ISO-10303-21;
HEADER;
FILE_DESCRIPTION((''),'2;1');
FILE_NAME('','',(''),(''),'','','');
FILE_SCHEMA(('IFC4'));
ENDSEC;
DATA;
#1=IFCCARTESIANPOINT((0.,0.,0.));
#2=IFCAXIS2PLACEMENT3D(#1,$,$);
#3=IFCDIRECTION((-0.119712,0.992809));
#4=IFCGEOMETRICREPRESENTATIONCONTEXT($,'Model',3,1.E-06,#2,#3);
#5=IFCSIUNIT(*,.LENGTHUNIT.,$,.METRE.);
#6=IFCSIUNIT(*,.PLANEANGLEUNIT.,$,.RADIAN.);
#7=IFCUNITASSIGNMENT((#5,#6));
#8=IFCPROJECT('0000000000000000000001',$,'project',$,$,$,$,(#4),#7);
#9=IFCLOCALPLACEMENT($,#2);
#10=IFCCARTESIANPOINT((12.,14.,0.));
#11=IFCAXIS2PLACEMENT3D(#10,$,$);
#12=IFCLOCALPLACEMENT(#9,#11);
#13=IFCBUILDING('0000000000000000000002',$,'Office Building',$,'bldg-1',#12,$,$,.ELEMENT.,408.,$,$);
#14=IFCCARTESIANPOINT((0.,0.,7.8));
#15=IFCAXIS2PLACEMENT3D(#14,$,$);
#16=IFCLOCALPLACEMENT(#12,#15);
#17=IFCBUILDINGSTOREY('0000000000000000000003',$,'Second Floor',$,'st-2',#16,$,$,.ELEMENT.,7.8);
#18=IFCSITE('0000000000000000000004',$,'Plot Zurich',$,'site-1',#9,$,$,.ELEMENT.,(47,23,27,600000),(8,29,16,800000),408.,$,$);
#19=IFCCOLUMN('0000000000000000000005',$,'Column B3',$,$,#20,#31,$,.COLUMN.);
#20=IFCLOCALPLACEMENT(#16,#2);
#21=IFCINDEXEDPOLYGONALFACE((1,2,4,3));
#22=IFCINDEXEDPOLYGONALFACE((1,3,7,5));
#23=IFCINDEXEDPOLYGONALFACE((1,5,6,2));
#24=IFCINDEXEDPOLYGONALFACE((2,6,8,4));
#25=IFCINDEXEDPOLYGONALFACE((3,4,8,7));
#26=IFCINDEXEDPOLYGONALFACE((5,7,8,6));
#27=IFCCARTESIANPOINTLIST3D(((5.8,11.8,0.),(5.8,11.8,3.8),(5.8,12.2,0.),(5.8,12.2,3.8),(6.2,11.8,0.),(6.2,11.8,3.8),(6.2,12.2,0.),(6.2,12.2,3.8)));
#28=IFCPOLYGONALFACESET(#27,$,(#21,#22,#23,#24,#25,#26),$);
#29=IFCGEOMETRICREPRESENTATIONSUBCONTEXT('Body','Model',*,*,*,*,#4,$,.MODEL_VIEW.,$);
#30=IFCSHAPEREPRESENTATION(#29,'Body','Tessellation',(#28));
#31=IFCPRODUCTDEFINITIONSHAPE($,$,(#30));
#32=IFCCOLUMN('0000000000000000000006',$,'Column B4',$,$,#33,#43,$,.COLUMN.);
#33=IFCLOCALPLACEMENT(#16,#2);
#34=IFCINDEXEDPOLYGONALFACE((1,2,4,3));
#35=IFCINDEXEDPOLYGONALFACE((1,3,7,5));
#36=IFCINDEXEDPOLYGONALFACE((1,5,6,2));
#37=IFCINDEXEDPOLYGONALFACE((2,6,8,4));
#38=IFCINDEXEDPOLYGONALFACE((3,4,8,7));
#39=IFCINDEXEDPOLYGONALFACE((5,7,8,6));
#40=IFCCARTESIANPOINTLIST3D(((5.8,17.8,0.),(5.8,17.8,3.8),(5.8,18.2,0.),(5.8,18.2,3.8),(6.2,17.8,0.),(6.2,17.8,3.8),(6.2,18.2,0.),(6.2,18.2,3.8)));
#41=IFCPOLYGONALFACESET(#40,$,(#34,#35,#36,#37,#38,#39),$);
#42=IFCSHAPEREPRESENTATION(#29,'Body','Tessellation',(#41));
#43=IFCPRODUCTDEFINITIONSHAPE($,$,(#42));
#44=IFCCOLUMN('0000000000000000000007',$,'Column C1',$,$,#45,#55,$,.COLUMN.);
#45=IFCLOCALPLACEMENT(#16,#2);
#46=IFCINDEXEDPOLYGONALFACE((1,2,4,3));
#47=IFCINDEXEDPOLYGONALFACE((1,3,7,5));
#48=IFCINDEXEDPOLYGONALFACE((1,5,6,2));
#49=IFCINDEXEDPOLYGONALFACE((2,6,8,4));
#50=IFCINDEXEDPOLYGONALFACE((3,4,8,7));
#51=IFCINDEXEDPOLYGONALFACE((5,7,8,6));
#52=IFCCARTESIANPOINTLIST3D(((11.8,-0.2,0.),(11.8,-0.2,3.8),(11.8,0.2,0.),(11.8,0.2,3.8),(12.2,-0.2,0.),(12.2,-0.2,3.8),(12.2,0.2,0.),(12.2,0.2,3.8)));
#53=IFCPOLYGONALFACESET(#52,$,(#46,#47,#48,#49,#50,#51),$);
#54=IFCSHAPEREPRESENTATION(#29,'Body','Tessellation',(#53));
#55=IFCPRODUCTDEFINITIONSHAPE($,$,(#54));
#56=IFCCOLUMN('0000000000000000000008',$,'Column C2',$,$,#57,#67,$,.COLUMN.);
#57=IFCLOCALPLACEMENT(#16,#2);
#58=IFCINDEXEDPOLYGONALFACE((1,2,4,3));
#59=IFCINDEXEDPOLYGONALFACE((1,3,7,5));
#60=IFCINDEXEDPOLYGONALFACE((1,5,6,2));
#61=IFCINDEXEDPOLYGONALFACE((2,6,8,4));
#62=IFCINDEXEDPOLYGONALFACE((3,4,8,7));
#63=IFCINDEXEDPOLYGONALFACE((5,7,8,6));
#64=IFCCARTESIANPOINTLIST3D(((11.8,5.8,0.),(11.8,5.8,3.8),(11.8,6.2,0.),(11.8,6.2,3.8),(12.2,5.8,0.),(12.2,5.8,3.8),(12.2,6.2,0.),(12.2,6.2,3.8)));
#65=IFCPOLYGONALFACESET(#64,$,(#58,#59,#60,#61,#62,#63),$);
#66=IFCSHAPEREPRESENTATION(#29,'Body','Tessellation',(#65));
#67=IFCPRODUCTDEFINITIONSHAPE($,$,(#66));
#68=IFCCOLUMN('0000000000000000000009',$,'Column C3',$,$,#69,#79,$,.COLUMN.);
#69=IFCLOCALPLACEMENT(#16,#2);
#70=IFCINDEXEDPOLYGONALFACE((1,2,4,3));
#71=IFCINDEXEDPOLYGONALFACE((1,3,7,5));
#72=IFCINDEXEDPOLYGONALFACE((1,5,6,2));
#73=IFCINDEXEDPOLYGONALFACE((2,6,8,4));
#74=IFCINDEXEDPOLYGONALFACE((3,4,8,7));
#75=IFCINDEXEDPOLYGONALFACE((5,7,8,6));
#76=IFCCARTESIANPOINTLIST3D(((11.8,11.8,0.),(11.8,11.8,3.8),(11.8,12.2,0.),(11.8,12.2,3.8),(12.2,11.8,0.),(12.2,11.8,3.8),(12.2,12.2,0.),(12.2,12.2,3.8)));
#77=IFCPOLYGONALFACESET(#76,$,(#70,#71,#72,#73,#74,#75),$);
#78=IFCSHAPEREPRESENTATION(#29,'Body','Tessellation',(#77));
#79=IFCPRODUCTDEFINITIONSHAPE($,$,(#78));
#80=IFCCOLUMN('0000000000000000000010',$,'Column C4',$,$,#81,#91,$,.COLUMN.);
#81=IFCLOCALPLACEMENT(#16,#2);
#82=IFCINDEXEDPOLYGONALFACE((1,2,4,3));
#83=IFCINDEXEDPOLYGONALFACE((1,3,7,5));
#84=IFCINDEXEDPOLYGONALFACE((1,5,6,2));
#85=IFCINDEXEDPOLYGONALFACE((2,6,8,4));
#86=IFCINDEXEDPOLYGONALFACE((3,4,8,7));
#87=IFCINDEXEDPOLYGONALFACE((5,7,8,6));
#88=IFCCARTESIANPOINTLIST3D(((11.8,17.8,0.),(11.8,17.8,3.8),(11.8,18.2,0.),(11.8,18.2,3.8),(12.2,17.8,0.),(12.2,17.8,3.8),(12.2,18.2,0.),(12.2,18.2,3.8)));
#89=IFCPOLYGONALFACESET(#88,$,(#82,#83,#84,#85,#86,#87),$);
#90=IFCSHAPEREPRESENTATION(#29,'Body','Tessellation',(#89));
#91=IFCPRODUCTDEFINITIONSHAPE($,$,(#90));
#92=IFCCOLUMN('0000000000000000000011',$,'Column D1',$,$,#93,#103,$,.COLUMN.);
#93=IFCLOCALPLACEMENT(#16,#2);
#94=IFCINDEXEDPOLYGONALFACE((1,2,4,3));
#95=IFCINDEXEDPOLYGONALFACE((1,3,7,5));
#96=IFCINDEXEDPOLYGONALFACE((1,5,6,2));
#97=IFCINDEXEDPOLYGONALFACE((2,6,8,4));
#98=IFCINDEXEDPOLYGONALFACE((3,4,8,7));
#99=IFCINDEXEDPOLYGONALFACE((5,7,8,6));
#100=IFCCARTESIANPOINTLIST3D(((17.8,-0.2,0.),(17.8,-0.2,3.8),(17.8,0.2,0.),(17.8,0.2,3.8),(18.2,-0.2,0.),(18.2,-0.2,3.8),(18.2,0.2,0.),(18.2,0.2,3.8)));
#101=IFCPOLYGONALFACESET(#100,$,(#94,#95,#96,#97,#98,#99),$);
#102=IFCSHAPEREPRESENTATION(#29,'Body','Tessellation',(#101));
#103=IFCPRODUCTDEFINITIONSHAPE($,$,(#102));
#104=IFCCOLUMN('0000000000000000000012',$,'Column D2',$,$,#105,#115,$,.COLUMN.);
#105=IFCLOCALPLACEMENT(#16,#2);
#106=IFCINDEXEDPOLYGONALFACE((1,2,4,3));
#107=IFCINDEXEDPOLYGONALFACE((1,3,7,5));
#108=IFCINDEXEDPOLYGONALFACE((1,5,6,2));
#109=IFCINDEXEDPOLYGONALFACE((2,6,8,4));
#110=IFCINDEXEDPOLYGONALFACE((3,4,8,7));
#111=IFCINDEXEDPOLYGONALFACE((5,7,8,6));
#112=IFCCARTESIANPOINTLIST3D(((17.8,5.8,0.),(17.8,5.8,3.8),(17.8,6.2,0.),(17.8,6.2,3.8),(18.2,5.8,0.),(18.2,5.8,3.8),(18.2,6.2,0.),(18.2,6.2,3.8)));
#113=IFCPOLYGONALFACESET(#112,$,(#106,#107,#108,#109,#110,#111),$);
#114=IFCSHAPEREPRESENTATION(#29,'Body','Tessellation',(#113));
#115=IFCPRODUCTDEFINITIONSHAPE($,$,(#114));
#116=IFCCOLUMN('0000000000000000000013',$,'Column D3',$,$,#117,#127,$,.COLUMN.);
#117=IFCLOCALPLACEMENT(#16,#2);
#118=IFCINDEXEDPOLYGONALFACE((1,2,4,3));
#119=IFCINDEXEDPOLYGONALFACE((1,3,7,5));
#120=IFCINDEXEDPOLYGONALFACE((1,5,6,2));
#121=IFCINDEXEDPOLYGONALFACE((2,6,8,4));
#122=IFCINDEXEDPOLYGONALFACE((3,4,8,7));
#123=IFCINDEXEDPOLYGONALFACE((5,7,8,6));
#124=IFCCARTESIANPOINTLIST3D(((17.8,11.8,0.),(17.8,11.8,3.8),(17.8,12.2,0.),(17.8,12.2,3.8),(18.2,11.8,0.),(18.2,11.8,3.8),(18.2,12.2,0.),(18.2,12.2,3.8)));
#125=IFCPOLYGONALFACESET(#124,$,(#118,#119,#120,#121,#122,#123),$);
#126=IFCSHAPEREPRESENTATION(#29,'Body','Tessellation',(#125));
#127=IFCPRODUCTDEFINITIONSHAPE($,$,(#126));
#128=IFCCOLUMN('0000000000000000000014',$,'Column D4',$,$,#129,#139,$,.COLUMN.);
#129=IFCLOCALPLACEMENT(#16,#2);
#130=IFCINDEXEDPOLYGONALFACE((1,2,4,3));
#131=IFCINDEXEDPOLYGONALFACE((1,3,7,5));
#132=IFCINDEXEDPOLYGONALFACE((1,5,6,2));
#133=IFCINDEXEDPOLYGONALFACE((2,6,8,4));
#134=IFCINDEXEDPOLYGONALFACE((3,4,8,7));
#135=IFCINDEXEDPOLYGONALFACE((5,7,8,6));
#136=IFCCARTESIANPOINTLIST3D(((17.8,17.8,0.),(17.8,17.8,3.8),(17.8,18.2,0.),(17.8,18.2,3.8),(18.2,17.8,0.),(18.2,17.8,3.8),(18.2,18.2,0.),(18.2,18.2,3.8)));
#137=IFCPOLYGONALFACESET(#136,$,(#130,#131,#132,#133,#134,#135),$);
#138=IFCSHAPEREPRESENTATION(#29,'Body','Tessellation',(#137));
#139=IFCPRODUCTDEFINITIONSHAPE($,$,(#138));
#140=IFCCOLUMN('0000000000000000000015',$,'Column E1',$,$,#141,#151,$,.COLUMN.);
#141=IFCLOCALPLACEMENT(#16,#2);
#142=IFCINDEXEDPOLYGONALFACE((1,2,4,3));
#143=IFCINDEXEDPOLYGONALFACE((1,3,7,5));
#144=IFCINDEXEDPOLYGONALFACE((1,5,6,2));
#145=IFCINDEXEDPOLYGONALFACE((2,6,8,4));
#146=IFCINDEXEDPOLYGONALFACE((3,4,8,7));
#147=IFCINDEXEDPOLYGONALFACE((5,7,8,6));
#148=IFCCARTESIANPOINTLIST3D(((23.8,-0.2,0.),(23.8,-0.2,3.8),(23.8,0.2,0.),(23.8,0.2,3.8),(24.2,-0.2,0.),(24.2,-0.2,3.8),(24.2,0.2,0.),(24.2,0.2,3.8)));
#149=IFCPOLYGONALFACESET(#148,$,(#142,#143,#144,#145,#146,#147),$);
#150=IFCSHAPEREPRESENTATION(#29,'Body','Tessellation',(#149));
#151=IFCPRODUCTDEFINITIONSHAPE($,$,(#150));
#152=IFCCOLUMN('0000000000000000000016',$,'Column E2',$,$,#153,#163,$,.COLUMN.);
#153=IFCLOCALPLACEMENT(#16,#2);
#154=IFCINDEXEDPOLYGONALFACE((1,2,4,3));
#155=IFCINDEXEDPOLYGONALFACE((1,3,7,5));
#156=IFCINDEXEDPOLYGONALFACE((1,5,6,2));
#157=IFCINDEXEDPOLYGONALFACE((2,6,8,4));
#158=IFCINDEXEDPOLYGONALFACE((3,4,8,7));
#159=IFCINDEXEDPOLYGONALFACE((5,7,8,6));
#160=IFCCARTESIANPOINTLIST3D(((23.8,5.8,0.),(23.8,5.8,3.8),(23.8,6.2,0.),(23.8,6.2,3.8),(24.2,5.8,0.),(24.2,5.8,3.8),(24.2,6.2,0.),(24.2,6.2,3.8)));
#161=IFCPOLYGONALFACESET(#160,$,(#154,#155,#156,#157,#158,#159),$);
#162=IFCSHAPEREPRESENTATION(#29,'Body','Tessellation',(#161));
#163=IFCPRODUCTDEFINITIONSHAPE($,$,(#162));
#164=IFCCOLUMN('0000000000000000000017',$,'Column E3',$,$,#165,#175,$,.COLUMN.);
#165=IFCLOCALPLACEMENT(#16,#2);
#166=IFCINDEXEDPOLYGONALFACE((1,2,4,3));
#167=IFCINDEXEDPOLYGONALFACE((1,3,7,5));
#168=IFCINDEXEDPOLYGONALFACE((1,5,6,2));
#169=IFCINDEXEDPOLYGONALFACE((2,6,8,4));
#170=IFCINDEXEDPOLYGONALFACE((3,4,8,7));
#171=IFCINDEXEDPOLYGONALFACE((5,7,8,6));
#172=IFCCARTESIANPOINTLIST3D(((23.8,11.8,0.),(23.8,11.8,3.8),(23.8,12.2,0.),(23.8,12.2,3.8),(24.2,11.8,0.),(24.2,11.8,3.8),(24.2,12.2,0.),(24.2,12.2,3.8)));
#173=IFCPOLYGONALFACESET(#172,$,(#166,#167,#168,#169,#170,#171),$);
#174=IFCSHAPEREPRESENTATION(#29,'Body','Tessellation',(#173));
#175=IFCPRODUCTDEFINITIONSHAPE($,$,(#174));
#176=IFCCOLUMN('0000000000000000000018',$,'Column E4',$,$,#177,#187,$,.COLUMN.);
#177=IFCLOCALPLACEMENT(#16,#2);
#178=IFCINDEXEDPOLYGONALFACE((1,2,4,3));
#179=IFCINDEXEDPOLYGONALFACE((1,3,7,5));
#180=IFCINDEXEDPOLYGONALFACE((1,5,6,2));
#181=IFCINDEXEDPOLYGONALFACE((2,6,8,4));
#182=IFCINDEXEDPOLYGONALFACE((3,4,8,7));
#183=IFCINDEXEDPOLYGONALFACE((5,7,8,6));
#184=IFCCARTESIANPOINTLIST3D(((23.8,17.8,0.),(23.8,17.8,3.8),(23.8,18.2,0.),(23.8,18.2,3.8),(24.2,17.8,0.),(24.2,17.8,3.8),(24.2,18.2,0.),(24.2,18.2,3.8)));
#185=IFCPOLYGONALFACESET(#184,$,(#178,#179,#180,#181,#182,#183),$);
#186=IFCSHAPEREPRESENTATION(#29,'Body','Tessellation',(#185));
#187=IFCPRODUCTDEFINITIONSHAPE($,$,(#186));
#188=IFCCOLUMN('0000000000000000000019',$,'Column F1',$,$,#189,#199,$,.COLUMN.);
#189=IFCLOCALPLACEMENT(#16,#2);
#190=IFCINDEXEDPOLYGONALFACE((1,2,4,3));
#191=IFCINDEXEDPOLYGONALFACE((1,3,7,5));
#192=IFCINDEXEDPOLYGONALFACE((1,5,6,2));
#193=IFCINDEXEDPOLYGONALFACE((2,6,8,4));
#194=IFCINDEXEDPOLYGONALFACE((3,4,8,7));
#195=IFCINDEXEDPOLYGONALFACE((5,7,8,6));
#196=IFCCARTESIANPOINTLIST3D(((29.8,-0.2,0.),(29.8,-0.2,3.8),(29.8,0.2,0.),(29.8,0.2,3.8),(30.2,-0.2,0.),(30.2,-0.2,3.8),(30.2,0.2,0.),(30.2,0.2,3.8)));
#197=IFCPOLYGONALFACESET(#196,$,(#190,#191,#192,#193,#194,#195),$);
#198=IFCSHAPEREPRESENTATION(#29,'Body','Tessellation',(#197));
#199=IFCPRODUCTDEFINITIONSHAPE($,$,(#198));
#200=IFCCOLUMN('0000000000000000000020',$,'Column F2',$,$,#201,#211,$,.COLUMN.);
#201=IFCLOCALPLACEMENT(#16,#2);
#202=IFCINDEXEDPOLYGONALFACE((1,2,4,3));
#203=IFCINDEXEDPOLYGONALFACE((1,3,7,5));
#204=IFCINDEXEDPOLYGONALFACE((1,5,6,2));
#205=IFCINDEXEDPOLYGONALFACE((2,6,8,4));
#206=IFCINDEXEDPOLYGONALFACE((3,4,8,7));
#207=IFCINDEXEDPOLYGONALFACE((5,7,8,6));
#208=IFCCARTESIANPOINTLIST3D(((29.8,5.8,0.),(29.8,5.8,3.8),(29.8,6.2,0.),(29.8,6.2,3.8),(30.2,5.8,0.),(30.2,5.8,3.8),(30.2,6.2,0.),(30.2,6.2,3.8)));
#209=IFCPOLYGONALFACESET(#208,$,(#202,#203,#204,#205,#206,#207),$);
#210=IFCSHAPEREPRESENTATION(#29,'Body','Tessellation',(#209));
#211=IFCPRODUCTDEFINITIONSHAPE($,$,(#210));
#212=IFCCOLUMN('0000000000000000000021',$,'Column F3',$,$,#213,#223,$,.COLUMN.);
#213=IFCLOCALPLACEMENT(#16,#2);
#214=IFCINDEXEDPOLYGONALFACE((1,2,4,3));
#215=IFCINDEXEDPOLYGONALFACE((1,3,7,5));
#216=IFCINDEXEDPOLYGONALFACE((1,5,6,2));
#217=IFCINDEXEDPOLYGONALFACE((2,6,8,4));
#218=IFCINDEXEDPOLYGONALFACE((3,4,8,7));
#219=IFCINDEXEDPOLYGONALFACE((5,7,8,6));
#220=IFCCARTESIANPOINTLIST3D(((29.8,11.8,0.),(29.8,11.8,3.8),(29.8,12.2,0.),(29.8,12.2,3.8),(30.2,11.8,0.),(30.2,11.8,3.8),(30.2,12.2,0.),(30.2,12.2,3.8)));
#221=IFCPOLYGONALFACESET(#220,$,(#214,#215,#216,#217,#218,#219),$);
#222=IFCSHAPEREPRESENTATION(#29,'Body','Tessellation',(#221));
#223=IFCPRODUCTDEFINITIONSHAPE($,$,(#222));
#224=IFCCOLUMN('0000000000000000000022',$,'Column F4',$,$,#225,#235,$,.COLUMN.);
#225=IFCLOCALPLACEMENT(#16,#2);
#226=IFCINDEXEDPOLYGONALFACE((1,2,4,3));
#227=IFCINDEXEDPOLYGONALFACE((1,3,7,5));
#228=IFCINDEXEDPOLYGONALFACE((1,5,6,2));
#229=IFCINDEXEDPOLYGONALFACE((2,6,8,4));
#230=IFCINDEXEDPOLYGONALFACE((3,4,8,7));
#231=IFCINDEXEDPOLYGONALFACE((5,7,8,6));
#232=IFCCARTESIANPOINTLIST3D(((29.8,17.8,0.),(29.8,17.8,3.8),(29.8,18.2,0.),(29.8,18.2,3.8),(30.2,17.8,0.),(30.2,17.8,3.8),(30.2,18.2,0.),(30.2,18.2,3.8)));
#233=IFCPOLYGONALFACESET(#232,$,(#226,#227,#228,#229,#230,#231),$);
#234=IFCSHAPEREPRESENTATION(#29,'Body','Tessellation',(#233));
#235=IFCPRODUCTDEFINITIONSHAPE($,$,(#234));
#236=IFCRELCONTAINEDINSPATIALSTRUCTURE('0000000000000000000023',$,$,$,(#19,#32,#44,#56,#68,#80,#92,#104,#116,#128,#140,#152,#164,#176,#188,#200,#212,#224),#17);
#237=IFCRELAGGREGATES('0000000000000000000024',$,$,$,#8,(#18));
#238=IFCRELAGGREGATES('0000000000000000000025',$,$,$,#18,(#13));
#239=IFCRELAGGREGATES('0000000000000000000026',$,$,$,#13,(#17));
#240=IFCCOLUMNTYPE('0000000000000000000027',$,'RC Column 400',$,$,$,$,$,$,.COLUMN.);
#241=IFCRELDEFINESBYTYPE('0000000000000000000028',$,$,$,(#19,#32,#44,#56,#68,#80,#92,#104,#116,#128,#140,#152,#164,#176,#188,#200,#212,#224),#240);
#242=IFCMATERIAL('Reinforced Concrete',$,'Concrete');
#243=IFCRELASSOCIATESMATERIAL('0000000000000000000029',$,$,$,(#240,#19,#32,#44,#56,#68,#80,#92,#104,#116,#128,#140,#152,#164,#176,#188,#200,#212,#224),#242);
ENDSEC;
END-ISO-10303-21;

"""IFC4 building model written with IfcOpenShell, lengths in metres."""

from ifc_helpers import new_model, si_unit, direction, frame, origin, origin_2d, place, context, subcontext, project, spatial, rectangle, extrude, material, type_object, element, save


model = new_model("IFC4")

# Units and contexts
model_context = context("Model", 3, precision=1e-06, world=origin(), true_north=direction((-0.119712, 0.992809)))
body_context = subcontext(model_context, "Body", "Model", "MODEL_VIEW")
ifc_project = project(units=[si_unit("LENGTHUNIT", "METRE"), si_unit("PLANEANGLEUNIT", "RADIAN")], contexts=[model_context])

# Site, building, storey
site_placement = place(None, origin())
site = spatial("IfcSite", under=ifc_project, at=site_placement, Name="Plot Zurich", ObjectType="site-1", CompositionType="ELEMENT", RefLatitude=(47, 23, 27, 600000), RefLongitude=(8, 29, 16, 800000), RefElevation=408.0)
building_placement = place(site_placement, frame((12.0, 14.0, 0.0)))
building = spatial("IfcBuilding", under=site, at=building_placement, Name="Office Building", ObjectType="bldg-1", CompositionType="ELEMENT", ElevationOfRefHeight=408.0)
storey_placement = place(building_placement, frame((0.0, 0.0, 7.8)))
storey = spatial("IfcBuildingStorey", under=building, at=storey_placement, Name="Second Floor", ObjectType="st-2", CompositionType="ELEMENT", Elevation=7.8)

# Columns
ifc_material_1 = material(Name="Reinforced Concrete", Category="Concrete")
column_type = type_object("IfcColumnType", Name="RC Column 400", PredefinedType="COLUMN", material=ifc_material_1)
for number, where, name in (
    (1, (6.0, 12.0, 0.0), "Column B3"),
    (2, (6.0, 18.0, 0.0), "Column B4"),
    (3, (12.0, 0.0, 0.0), "Column C1"),
    (4, (12.0, 6.0, 0.0), "Column C2"),
    (5, (12.0, 12.0, 0.0), "Column C3"),
    (6, (12.0, 18.0, 0.0), "Column C4"),
    (7, (18.0, 0.0, 0.0), "Column D1"),
    (8, (18.0, 6.0, 0.0), "Column D2"),
    (9, (18.0, 12.0, 0.0), "Column D3"),
    (10, (18.0, 18.0, 0.0), "Column D4"),
    (11, (24.0, 0.0, 0.0), "Column E1"),
    (12, (24.0, 6.0, 0.0), "Column E2"),
    (13, (24.0, 12.0, 0.0), "Column E3"),
    (14, (24.0, 18.0, 0.0), "Column E4"),
    (15, (30.0, 0.0, 0.0), "Column F1"),
    (16, (30.0, 6.0, 0.0), "Column F2"),
    (17, (30.0, 12.0, 0.0), "Column F3"),
    (18, (30.0, 18.0, 0.0), "Column F4"),
):
    element("IfcColumn", number, at=place(storey_placement, frame(where)), inside=storey, type_object=column_type, material=ifc_material_1, Name=name, PredefinedType="COLUMN", context=body_context, shape_type="SweptSolid", body=[
        extrude(rectangle(XDim=0.4, YDim=0.4, at=origin_2d()), origin(), (0.0, 0.0, 1.0), 3.8),
    ])

save(model, "model.ifc")
